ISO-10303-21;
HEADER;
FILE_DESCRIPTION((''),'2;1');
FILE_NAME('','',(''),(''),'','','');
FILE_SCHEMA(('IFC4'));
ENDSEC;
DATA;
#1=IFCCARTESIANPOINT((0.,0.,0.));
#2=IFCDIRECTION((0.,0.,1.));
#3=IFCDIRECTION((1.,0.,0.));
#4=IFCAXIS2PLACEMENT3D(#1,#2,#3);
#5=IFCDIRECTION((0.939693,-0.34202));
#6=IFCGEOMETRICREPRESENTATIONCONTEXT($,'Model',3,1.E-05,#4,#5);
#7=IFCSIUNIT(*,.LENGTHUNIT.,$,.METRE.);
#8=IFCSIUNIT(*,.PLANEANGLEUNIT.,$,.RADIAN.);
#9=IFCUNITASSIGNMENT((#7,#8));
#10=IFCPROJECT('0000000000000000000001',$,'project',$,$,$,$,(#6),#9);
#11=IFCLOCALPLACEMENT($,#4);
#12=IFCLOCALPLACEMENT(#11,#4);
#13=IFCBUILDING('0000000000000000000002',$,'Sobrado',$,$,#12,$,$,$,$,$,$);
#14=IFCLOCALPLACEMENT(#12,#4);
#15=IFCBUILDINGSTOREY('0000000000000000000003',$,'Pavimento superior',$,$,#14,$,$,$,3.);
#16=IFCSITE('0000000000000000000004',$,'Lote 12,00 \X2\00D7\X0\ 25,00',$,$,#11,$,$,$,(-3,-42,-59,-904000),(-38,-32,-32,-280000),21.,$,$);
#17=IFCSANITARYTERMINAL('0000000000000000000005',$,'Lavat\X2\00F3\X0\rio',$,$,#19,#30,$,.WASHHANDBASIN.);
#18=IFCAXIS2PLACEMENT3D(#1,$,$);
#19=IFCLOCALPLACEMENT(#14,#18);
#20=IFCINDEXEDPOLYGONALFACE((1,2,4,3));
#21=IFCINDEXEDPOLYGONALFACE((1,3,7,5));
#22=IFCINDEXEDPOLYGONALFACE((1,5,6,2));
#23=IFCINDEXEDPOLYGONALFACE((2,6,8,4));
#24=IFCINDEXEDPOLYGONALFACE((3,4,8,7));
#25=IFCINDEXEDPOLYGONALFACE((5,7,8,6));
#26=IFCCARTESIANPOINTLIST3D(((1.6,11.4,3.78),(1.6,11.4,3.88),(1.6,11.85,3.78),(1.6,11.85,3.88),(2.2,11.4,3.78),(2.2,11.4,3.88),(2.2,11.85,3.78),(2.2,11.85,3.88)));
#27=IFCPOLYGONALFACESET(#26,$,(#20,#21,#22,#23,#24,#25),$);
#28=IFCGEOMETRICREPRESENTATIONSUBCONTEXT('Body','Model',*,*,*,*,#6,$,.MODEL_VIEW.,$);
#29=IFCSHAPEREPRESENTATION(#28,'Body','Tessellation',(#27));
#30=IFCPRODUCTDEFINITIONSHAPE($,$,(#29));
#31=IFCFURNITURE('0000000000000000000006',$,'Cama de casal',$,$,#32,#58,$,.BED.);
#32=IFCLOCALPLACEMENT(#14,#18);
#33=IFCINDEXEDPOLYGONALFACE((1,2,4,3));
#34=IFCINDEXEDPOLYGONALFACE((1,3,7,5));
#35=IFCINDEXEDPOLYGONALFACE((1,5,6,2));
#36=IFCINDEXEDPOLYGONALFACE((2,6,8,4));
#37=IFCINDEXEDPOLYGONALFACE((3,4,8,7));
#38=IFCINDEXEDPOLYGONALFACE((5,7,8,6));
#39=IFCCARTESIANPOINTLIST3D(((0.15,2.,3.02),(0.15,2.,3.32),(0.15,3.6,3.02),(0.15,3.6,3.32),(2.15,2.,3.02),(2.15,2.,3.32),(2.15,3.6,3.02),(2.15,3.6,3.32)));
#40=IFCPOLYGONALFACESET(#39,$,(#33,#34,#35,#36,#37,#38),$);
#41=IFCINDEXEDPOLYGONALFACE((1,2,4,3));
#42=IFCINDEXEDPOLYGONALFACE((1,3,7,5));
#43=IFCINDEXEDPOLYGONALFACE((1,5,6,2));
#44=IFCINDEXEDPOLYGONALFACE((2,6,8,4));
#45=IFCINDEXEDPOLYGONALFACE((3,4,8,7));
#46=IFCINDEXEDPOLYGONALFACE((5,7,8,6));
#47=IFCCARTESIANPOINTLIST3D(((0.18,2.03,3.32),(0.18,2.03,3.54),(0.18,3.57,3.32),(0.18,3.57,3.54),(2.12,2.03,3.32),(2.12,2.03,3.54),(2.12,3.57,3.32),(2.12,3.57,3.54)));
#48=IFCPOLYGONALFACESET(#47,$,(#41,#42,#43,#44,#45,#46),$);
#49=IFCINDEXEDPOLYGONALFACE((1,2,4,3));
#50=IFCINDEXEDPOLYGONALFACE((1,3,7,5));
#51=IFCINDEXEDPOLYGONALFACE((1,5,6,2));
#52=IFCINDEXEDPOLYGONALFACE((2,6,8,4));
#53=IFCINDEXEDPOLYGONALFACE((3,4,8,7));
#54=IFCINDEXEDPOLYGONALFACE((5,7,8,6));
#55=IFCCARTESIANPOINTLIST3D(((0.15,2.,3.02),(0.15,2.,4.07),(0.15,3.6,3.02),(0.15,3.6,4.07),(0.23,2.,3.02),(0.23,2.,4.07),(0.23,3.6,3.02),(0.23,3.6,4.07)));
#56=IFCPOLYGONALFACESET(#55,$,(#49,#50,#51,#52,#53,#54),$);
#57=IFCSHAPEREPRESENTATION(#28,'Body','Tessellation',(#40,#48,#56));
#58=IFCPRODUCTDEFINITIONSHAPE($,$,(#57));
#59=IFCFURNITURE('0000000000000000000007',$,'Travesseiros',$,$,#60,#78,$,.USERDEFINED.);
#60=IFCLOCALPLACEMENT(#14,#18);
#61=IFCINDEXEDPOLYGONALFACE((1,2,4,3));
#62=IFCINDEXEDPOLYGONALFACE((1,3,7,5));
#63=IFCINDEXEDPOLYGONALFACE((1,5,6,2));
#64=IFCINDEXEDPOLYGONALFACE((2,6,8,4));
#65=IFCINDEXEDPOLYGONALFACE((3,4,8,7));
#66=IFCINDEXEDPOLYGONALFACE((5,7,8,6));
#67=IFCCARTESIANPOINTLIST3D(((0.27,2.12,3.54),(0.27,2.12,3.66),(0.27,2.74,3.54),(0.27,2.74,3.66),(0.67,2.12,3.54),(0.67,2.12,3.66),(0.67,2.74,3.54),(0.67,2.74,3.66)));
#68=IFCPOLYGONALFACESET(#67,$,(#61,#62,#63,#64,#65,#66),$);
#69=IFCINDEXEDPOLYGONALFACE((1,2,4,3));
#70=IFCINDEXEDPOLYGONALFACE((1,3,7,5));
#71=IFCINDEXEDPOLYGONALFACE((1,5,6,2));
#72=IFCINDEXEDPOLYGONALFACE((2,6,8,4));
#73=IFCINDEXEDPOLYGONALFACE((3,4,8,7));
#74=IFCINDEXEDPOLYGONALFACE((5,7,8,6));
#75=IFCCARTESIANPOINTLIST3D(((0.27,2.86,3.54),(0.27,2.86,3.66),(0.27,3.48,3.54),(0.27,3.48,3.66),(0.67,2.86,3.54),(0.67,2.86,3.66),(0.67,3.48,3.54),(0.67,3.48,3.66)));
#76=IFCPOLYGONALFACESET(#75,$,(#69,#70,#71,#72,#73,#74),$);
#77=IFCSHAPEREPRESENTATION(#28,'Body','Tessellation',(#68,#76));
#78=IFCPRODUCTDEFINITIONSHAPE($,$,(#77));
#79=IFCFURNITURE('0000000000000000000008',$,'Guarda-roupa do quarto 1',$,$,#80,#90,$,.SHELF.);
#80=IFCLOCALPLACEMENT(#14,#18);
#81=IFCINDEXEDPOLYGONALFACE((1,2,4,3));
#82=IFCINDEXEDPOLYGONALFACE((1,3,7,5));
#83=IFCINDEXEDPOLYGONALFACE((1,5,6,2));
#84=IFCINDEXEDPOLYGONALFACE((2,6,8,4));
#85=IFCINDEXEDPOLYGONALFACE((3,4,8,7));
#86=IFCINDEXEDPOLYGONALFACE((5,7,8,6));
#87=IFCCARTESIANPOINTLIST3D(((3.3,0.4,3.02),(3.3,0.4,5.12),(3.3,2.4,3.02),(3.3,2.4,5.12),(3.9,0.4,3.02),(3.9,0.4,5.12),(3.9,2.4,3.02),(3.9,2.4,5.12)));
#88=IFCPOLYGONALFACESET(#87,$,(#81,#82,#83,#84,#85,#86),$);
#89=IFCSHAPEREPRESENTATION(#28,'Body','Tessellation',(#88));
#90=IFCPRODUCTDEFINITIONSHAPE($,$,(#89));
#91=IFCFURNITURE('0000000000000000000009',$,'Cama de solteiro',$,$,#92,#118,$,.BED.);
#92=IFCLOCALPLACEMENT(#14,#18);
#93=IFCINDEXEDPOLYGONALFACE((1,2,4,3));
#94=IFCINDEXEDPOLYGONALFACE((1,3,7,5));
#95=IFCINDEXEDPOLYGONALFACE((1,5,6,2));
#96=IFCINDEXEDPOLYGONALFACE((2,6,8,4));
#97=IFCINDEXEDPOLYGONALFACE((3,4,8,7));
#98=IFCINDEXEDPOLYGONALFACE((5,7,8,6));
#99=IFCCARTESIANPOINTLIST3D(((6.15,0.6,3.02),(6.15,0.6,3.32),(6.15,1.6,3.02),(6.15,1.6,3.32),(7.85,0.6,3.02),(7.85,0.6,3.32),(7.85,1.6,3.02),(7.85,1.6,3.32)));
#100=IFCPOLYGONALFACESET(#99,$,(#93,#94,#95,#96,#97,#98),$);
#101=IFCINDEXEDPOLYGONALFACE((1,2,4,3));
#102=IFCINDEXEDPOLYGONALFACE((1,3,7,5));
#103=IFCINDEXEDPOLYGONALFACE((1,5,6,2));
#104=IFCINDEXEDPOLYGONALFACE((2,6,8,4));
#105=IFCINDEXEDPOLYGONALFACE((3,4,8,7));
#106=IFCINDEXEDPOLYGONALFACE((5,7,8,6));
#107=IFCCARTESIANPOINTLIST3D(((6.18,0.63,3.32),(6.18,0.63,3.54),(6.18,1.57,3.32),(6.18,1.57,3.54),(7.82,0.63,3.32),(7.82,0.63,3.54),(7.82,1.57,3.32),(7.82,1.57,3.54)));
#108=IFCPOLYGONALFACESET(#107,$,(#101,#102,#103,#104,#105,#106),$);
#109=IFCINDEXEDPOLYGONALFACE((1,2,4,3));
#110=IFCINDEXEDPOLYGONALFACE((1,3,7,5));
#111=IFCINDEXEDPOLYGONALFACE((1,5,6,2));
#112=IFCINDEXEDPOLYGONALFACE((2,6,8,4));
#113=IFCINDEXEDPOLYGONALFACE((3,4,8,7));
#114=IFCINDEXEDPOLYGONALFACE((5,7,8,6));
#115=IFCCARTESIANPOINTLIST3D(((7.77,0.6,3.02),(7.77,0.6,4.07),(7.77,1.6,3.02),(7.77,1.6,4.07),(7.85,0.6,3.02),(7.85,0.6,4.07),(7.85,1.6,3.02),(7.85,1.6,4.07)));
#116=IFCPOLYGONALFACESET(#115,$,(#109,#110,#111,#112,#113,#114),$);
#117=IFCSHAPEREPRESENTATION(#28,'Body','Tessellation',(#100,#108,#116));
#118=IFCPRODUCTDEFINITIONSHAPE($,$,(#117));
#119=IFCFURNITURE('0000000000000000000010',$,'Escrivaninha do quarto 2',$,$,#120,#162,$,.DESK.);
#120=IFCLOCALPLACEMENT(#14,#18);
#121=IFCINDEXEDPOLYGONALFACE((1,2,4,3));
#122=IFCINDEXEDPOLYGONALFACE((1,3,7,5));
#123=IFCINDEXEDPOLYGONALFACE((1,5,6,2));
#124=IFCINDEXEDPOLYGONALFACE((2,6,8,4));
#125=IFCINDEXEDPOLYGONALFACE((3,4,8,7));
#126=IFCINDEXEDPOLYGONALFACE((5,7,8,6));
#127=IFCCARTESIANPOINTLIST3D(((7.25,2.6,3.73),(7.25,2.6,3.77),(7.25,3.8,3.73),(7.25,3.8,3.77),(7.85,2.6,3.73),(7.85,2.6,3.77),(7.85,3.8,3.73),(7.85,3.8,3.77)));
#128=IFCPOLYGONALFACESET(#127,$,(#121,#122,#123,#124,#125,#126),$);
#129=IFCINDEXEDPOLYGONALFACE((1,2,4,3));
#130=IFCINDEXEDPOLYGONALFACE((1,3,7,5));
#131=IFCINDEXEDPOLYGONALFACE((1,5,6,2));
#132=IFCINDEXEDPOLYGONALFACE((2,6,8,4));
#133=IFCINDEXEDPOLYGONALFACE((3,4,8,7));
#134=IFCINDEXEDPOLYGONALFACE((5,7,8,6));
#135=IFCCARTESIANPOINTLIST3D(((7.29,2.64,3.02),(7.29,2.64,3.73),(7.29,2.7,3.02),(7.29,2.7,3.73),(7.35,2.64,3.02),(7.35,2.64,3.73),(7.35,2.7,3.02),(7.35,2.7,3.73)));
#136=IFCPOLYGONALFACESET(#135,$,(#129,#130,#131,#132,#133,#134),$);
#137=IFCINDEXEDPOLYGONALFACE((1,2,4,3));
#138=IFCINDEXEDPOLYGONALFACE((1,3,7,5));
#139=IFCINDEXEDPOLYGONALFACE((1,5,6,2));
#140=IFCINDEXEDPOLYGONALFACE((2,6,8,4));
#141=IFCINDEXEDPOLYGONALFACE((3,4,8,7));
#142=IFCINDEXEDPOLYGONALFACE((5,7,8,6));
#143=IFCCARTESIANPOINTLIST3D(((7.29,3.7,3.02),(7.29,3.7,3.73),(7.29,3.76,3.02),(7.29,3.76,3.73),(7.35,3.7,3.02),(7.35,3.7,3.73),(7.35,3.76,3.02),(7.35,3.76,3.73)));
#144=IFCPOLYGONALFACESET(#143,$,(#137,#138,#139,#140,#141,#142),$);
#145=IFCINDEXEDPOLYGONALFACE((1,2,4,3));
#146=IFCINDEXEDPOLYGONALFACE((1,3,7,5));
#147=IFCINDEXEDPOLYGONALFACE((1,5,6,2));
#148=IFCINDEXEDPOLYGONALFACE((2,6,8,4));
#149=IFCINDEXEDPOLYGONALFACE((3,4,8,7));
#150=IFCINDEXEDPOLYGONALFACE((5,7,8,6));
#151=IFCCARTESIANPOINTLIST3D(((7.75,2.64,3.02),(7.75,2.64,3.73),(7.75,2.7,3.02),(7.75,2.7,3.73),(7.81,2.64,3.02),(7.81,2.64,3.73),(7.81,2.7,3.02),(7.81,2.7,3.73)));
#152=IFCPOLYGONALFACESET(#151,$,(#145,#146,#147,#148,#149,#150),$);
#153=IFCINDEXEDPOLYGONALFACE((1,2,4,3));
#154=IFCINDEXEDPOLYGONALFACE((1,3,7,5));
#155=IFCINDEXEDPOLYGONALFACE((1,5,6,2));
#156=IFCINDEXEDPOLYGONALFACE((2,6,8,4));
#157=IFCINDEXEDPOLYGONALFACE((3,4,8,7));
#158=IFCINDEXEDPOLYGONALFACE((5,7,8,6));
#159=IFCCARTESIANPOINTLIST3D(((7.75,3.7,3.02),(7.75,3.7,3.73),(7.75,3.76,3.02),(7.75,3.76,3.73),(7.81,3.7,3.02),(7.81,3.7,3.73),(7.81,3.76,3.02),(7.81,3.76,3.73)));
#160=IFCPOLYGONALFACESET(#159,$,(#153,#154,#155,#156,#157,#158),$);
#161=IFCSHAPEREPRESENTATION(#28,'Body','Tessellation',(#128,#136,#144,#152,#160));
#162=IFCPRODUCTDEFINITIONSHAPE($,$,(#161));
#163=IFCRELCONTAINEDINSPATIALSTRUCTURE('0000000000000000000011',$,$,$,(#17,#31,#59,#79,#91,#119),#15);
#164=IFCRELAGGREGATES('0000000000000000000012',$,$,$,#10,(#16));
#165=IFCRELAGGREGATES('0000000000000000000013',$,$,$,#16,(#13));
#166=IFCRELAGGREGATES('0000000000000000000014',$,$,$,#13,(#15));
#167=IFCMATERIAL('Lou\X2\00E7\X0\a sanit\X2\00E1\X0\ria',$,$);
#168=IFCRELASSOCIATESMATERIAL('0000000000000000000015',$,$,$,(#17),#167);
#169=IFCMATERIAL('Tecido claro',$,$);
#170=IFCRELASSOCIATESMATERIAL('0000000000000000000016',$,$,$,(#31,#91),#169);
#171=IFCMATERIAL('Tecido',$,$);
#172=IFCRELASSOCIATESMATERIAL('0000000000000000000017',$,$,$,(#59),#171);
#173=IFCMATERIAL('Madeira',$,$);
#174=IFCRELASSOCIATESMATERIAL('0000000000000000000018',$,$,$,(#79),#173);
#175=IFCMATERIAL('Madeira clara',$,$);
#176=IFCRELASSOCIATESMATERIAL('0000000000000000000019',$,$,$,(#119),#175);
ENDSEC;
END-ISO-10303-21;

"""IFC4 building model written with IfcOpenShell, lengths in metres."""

from ifc_helpers import new_model, si_unit, direction, frame, origin_with_axes, place, context, subcontext, project, spatial, line, indexed_curve, outline, extrude, material, element, save


model = new_model("IFC4")

# Units and contexts
model_context = context("Model", 3, precision=1e-05, world=origin_with_axes(), true_north=direction((0.939693, -0.34202)))
body_context = subcontext(model_context, "Body", "Model", "MODEL_VIEW")
ifc_project = project(units=[si_unit("LENGTHUNIT", "METRE"), si_unit("PLANEANGLEUNIT", "RADIAN")], contexts=[model_context])

# Site, building, storey
site_placement = place(None, origin_with_axes())
site = spatial("IfcSite", under=ifc_project, at=site_placement, Name="Lote 12,00 × 25,00", RefLatitude=(-3, -42, -59, -904000), RefLongitude=(-38, -32, -32, -280000), RefElevation=21.0)
building_placement = place(site_placement, origin_with_axes())
building = spatial("IfcBuilding", under=site, at=building_placement, Name="Sobrado")
storey_placement = place(building_placement, origin_with_axes())
storey = spatial("IfcBuildingStorey", under=building, at=storey_placement, Name="Pavimento superior", Elevation=3.0)

# Sanitary terminal
ifc_material_1 = material(Name="Louça sanitária")
sanitary_terminal_1_placement = place(storey_placement, origin_with_axes())
element("IfcSanitaryTerminal", 1, at=sanitary_terminal_1_placement, inside=storey, material=ifc_material_1, Name="Lavatório", PredefinedType="WASHHANDBASIN", context=body_context, shape_type="SweptSolid", body=[
    extrude(outline(indexed_curve([(1.6, 11.4), (2.2, 11.4), (2.2, 11.85), (1.6, 11.85)], segments=[line(1, 2, 3, 4, 1)])), frame((0.0, 0.0, 3.78), z_axis=(0.0, 0.0, 1.0), x_axis=(1.0, 0.0, 0.0)), (0.0, 0.0, 1.0), 0.1),
])

# Furniture
ifc_material_2 = material(Name="Tecido claro")
furniture_1_placement = place(storey_placement, origin_with_axes())
element("IfcFurniture", 2, at=furniture_1_placement, inside=storey, material=ifc_material_2, Name="Cama de casal", PredefinedType="BED", context=body_context, shape_type="SweptSolid", body=[
    extrude(outline(indexed_curve([(0.15, 2.0), (2.15, 2.0), (2.15, 3.6), (0.15, 3.6)], segments=[line(1, 2, 3, 4, 1)])), frame((0.0, 0.0, 3.02), z_axis=(0.0, 0.0, 1.0), x_axis=(1.0, 0.0, 0.0)), (0.0, 0.0, 1.0), 0.3),
    extrude(outline(indexed_curve([(0.18, 2.03), (2.12, 2.03), (2.12, 3.57), (0.18, 3.57)], segments=[line(1, 2, 3, 4, 1)])), frame((0.0, 0.0, 3.32), z_axis=(0.0, 0.0, 1.0), x_axis=(1.0, 0.0, 0.0)), (0.0, 0.0, 1.0), 0.22),
    extrude(outline(indexed_curve([(0.15, 2.0), (0.23, 2.0), (0.23, 3.6), (0.15, 3.6)], segments=[line(1, 2, 3, 4, 1)])), frame((0.0, 0.0, 3.02), z_axis=(0.0, 0.0, 1.0), x_axis=(1.0, 0.0, 0.0)), (0.0, 0.0, 1.0), 1.05),
])
ifc_material_3 = material(Name="Tecido")
furniture_2_placement = place(storey_placement, origin_with_axes())
element("IfcFurniture", 3, at=furniture_2_placement, inside=storey, material=ifc_material_3, Name="Travesseiros", PredefinedType="USERDEFINED", context=body_context, shape_type="SweptSolid", body=[
    extrude(outline(indexed_curve([(0.27, 2.12), (0.67, 2.12), (0.67, 2.74), (0.27, 2.74)], segments=[line(1, 2, 3, 4, 1)])), frame((0.0, 0.0, 3.54), z_axis=(0.0, 0.0, 1.0), x_axis=(1.0, 0.0, 0.0)), (0.0, 0.0, 1.0), 0.12),
    extrude(outline(indexed_curve([(0.27, 2.86), (0.67, 2.86), (0.67, 3.48), (0.27, 3.48)], segments=[line(1, 2, 3, 4, 1)])), frame((0.0, 0.0, 3.54), z_axis=(0.0, 0.0, 1.0), x_axis=(1.0, 0.0, 0.0)), (0.0, 0.0, 1.0), 0.12),
])
ifc_material_4 = material(Name="Madeira")
furniture_3_placement = place(storey_placement, origin_with_axes())
element("IfcFurniture", 4, at=furniture_3_placement, inside=storey, material=ifc_material_4, Name="Guarda-roupa do quarto 1", PredefinedType="SHELF", context=body_context, shape_type="SweptSolid", body=[
    extrude(outline(indexed_curve([(3.3, 0.4), (3.9, 0.4), (3.9, 2.4), (3.3, 2.4)], segments=[line(1, 2, 3, 4, 1)])), frame((0.0, 0.0, 3.02), z_axis=(0.0, 0.0, 1.0), x_axis=(1.0, 0.0, 0.0)), (0.0, 0.0, 1.0), 2.1),
])
furniture_4_placement = place(storey_placement, origin_with_axes())
element("IfcFurniture", 5, at=furniture_4_placement, inside=storey, material=ifc_material_2, Name="Cama de solteiro", PredefinedType="BED", context=body_context, shape_type="SweptSolid", body=[
    extrude(outline(indexed_curve([(6.15, 0.6), (7.85, 0.6), (7.85, 1.6), (6.15, 1.6)], segments=[line(1, 2, 3, 4, 1)])), frame((0.0, 0.0, 3.02), z_axis=(0.0, 0.0, 1.0), x_axis=(1.0, 0.0, 0.0)), (0.0, 0.0, 1.0), 0.3),
    extrude(outline(indexed_curve([(6.18, 0.63), (7.82, 0.63), (7.82, 1.57), (6.18, 1.57)], segments=[line(1, 2, 3, 4, 1)])), frame((0.0, 0.0, 3.32), z_axis=(0.0, 0.0, 1.0), x_axis=(1.0, 0.0, 0.0)), (0.0, 0.0, 1.0), 0.22),
    extrude(outline(indexed_curve([(7.77, 0.6), (7.85, 0.6), (7.85, 1.6), (7.77, 1.6)], segments=[line(1, 2, 3, 4, 1)])), frame((0.0, 0.0, 3.02), z_axis=(0.0, 0.0, 1.0), x_axis=(1.0, 0.0, 0.0)), (0.0, 0.0, 1.0), 1.05),
])
ifc_material_5 = material(Name="Madeira clara")
furniture_5_placement = place(storey_placement, origin_with_axes())
element("IfcFurniture", 6, at=furniture_5_placement, inside=storey, material=ifc_material_5, Name="Escrivaninha do quarto 2", PredefinedType="DESK", context=body_context, shape_type="SweptSolid", body=[
    extrude(outline(indexed_curve([(7.25, 2.6), (7.85, 2.6), (7.85, 3.8), (7.25, 3.8)], segments=[line(1, 2, 3, 4, 1)])), frame((0.0, 0.0, 3.73), z_axis=(0.0, 0.0, 1.0), x_axis=(1.0, 0.0, 0.0)), (0.0, 0.0, 1.0), 0.04),
    extrude(outline(indexed_curve([(7.29, 2.64), (7.35, 2.64), (7.35, 2.7), (7.29, 2.7)], segments=[line(1, 2, 3, 4, 1)])), frame((0.0, 0.0, 3.02), z_axis=(0.0, 0.0, 1.0), x_axis=(1.0, 0.0, 0.0)), (0.0, 0.0, 1.0), 0.71),
    extrude(outline(indexed_curve([(7.29, 3.7), (7.35, 3.7), (7.35, 3.76), (7.29, 3.76)], segments=[line(1, 2, 3, 4, 1)])), frame((0.0, 0.0, 3.02), z_axis=(0.0, 0.0, 1.0), x_axis=(1.0, 0.0, 0.0)), (0.0, 0.0, 1.0), 0.71),
    extrude(outline(indexed_curve([(7.75, 2.64), (7.81, 2.64), (7.81, 2.7), (7.75, 2.7)], segments=[line(1, 2, 3, 4, 1)])), frame((0.0, 0.0, 3.02), z_axis=(0.0, 0.0, 1.0), x_axis=(1.0, 0.0, 0.0)), (0.0, 0.0, 1.0), 0.71),
    extrude(outline(indexed_curve([(7.75, 3.7), (7.81, 3.7), (7.81, 3.76), (7.75, 3.76)], segments=[line(1, 2, 3, 4, 1)])), frame((0.0, 0.0, 3.02), z_axis=(0.0, 0.0, 1.0), x_axis=(1.0, 0.0, 0.0)), (0.0, 0.0, 1.0), 0.71),
])

save(model, "model.ifc")
